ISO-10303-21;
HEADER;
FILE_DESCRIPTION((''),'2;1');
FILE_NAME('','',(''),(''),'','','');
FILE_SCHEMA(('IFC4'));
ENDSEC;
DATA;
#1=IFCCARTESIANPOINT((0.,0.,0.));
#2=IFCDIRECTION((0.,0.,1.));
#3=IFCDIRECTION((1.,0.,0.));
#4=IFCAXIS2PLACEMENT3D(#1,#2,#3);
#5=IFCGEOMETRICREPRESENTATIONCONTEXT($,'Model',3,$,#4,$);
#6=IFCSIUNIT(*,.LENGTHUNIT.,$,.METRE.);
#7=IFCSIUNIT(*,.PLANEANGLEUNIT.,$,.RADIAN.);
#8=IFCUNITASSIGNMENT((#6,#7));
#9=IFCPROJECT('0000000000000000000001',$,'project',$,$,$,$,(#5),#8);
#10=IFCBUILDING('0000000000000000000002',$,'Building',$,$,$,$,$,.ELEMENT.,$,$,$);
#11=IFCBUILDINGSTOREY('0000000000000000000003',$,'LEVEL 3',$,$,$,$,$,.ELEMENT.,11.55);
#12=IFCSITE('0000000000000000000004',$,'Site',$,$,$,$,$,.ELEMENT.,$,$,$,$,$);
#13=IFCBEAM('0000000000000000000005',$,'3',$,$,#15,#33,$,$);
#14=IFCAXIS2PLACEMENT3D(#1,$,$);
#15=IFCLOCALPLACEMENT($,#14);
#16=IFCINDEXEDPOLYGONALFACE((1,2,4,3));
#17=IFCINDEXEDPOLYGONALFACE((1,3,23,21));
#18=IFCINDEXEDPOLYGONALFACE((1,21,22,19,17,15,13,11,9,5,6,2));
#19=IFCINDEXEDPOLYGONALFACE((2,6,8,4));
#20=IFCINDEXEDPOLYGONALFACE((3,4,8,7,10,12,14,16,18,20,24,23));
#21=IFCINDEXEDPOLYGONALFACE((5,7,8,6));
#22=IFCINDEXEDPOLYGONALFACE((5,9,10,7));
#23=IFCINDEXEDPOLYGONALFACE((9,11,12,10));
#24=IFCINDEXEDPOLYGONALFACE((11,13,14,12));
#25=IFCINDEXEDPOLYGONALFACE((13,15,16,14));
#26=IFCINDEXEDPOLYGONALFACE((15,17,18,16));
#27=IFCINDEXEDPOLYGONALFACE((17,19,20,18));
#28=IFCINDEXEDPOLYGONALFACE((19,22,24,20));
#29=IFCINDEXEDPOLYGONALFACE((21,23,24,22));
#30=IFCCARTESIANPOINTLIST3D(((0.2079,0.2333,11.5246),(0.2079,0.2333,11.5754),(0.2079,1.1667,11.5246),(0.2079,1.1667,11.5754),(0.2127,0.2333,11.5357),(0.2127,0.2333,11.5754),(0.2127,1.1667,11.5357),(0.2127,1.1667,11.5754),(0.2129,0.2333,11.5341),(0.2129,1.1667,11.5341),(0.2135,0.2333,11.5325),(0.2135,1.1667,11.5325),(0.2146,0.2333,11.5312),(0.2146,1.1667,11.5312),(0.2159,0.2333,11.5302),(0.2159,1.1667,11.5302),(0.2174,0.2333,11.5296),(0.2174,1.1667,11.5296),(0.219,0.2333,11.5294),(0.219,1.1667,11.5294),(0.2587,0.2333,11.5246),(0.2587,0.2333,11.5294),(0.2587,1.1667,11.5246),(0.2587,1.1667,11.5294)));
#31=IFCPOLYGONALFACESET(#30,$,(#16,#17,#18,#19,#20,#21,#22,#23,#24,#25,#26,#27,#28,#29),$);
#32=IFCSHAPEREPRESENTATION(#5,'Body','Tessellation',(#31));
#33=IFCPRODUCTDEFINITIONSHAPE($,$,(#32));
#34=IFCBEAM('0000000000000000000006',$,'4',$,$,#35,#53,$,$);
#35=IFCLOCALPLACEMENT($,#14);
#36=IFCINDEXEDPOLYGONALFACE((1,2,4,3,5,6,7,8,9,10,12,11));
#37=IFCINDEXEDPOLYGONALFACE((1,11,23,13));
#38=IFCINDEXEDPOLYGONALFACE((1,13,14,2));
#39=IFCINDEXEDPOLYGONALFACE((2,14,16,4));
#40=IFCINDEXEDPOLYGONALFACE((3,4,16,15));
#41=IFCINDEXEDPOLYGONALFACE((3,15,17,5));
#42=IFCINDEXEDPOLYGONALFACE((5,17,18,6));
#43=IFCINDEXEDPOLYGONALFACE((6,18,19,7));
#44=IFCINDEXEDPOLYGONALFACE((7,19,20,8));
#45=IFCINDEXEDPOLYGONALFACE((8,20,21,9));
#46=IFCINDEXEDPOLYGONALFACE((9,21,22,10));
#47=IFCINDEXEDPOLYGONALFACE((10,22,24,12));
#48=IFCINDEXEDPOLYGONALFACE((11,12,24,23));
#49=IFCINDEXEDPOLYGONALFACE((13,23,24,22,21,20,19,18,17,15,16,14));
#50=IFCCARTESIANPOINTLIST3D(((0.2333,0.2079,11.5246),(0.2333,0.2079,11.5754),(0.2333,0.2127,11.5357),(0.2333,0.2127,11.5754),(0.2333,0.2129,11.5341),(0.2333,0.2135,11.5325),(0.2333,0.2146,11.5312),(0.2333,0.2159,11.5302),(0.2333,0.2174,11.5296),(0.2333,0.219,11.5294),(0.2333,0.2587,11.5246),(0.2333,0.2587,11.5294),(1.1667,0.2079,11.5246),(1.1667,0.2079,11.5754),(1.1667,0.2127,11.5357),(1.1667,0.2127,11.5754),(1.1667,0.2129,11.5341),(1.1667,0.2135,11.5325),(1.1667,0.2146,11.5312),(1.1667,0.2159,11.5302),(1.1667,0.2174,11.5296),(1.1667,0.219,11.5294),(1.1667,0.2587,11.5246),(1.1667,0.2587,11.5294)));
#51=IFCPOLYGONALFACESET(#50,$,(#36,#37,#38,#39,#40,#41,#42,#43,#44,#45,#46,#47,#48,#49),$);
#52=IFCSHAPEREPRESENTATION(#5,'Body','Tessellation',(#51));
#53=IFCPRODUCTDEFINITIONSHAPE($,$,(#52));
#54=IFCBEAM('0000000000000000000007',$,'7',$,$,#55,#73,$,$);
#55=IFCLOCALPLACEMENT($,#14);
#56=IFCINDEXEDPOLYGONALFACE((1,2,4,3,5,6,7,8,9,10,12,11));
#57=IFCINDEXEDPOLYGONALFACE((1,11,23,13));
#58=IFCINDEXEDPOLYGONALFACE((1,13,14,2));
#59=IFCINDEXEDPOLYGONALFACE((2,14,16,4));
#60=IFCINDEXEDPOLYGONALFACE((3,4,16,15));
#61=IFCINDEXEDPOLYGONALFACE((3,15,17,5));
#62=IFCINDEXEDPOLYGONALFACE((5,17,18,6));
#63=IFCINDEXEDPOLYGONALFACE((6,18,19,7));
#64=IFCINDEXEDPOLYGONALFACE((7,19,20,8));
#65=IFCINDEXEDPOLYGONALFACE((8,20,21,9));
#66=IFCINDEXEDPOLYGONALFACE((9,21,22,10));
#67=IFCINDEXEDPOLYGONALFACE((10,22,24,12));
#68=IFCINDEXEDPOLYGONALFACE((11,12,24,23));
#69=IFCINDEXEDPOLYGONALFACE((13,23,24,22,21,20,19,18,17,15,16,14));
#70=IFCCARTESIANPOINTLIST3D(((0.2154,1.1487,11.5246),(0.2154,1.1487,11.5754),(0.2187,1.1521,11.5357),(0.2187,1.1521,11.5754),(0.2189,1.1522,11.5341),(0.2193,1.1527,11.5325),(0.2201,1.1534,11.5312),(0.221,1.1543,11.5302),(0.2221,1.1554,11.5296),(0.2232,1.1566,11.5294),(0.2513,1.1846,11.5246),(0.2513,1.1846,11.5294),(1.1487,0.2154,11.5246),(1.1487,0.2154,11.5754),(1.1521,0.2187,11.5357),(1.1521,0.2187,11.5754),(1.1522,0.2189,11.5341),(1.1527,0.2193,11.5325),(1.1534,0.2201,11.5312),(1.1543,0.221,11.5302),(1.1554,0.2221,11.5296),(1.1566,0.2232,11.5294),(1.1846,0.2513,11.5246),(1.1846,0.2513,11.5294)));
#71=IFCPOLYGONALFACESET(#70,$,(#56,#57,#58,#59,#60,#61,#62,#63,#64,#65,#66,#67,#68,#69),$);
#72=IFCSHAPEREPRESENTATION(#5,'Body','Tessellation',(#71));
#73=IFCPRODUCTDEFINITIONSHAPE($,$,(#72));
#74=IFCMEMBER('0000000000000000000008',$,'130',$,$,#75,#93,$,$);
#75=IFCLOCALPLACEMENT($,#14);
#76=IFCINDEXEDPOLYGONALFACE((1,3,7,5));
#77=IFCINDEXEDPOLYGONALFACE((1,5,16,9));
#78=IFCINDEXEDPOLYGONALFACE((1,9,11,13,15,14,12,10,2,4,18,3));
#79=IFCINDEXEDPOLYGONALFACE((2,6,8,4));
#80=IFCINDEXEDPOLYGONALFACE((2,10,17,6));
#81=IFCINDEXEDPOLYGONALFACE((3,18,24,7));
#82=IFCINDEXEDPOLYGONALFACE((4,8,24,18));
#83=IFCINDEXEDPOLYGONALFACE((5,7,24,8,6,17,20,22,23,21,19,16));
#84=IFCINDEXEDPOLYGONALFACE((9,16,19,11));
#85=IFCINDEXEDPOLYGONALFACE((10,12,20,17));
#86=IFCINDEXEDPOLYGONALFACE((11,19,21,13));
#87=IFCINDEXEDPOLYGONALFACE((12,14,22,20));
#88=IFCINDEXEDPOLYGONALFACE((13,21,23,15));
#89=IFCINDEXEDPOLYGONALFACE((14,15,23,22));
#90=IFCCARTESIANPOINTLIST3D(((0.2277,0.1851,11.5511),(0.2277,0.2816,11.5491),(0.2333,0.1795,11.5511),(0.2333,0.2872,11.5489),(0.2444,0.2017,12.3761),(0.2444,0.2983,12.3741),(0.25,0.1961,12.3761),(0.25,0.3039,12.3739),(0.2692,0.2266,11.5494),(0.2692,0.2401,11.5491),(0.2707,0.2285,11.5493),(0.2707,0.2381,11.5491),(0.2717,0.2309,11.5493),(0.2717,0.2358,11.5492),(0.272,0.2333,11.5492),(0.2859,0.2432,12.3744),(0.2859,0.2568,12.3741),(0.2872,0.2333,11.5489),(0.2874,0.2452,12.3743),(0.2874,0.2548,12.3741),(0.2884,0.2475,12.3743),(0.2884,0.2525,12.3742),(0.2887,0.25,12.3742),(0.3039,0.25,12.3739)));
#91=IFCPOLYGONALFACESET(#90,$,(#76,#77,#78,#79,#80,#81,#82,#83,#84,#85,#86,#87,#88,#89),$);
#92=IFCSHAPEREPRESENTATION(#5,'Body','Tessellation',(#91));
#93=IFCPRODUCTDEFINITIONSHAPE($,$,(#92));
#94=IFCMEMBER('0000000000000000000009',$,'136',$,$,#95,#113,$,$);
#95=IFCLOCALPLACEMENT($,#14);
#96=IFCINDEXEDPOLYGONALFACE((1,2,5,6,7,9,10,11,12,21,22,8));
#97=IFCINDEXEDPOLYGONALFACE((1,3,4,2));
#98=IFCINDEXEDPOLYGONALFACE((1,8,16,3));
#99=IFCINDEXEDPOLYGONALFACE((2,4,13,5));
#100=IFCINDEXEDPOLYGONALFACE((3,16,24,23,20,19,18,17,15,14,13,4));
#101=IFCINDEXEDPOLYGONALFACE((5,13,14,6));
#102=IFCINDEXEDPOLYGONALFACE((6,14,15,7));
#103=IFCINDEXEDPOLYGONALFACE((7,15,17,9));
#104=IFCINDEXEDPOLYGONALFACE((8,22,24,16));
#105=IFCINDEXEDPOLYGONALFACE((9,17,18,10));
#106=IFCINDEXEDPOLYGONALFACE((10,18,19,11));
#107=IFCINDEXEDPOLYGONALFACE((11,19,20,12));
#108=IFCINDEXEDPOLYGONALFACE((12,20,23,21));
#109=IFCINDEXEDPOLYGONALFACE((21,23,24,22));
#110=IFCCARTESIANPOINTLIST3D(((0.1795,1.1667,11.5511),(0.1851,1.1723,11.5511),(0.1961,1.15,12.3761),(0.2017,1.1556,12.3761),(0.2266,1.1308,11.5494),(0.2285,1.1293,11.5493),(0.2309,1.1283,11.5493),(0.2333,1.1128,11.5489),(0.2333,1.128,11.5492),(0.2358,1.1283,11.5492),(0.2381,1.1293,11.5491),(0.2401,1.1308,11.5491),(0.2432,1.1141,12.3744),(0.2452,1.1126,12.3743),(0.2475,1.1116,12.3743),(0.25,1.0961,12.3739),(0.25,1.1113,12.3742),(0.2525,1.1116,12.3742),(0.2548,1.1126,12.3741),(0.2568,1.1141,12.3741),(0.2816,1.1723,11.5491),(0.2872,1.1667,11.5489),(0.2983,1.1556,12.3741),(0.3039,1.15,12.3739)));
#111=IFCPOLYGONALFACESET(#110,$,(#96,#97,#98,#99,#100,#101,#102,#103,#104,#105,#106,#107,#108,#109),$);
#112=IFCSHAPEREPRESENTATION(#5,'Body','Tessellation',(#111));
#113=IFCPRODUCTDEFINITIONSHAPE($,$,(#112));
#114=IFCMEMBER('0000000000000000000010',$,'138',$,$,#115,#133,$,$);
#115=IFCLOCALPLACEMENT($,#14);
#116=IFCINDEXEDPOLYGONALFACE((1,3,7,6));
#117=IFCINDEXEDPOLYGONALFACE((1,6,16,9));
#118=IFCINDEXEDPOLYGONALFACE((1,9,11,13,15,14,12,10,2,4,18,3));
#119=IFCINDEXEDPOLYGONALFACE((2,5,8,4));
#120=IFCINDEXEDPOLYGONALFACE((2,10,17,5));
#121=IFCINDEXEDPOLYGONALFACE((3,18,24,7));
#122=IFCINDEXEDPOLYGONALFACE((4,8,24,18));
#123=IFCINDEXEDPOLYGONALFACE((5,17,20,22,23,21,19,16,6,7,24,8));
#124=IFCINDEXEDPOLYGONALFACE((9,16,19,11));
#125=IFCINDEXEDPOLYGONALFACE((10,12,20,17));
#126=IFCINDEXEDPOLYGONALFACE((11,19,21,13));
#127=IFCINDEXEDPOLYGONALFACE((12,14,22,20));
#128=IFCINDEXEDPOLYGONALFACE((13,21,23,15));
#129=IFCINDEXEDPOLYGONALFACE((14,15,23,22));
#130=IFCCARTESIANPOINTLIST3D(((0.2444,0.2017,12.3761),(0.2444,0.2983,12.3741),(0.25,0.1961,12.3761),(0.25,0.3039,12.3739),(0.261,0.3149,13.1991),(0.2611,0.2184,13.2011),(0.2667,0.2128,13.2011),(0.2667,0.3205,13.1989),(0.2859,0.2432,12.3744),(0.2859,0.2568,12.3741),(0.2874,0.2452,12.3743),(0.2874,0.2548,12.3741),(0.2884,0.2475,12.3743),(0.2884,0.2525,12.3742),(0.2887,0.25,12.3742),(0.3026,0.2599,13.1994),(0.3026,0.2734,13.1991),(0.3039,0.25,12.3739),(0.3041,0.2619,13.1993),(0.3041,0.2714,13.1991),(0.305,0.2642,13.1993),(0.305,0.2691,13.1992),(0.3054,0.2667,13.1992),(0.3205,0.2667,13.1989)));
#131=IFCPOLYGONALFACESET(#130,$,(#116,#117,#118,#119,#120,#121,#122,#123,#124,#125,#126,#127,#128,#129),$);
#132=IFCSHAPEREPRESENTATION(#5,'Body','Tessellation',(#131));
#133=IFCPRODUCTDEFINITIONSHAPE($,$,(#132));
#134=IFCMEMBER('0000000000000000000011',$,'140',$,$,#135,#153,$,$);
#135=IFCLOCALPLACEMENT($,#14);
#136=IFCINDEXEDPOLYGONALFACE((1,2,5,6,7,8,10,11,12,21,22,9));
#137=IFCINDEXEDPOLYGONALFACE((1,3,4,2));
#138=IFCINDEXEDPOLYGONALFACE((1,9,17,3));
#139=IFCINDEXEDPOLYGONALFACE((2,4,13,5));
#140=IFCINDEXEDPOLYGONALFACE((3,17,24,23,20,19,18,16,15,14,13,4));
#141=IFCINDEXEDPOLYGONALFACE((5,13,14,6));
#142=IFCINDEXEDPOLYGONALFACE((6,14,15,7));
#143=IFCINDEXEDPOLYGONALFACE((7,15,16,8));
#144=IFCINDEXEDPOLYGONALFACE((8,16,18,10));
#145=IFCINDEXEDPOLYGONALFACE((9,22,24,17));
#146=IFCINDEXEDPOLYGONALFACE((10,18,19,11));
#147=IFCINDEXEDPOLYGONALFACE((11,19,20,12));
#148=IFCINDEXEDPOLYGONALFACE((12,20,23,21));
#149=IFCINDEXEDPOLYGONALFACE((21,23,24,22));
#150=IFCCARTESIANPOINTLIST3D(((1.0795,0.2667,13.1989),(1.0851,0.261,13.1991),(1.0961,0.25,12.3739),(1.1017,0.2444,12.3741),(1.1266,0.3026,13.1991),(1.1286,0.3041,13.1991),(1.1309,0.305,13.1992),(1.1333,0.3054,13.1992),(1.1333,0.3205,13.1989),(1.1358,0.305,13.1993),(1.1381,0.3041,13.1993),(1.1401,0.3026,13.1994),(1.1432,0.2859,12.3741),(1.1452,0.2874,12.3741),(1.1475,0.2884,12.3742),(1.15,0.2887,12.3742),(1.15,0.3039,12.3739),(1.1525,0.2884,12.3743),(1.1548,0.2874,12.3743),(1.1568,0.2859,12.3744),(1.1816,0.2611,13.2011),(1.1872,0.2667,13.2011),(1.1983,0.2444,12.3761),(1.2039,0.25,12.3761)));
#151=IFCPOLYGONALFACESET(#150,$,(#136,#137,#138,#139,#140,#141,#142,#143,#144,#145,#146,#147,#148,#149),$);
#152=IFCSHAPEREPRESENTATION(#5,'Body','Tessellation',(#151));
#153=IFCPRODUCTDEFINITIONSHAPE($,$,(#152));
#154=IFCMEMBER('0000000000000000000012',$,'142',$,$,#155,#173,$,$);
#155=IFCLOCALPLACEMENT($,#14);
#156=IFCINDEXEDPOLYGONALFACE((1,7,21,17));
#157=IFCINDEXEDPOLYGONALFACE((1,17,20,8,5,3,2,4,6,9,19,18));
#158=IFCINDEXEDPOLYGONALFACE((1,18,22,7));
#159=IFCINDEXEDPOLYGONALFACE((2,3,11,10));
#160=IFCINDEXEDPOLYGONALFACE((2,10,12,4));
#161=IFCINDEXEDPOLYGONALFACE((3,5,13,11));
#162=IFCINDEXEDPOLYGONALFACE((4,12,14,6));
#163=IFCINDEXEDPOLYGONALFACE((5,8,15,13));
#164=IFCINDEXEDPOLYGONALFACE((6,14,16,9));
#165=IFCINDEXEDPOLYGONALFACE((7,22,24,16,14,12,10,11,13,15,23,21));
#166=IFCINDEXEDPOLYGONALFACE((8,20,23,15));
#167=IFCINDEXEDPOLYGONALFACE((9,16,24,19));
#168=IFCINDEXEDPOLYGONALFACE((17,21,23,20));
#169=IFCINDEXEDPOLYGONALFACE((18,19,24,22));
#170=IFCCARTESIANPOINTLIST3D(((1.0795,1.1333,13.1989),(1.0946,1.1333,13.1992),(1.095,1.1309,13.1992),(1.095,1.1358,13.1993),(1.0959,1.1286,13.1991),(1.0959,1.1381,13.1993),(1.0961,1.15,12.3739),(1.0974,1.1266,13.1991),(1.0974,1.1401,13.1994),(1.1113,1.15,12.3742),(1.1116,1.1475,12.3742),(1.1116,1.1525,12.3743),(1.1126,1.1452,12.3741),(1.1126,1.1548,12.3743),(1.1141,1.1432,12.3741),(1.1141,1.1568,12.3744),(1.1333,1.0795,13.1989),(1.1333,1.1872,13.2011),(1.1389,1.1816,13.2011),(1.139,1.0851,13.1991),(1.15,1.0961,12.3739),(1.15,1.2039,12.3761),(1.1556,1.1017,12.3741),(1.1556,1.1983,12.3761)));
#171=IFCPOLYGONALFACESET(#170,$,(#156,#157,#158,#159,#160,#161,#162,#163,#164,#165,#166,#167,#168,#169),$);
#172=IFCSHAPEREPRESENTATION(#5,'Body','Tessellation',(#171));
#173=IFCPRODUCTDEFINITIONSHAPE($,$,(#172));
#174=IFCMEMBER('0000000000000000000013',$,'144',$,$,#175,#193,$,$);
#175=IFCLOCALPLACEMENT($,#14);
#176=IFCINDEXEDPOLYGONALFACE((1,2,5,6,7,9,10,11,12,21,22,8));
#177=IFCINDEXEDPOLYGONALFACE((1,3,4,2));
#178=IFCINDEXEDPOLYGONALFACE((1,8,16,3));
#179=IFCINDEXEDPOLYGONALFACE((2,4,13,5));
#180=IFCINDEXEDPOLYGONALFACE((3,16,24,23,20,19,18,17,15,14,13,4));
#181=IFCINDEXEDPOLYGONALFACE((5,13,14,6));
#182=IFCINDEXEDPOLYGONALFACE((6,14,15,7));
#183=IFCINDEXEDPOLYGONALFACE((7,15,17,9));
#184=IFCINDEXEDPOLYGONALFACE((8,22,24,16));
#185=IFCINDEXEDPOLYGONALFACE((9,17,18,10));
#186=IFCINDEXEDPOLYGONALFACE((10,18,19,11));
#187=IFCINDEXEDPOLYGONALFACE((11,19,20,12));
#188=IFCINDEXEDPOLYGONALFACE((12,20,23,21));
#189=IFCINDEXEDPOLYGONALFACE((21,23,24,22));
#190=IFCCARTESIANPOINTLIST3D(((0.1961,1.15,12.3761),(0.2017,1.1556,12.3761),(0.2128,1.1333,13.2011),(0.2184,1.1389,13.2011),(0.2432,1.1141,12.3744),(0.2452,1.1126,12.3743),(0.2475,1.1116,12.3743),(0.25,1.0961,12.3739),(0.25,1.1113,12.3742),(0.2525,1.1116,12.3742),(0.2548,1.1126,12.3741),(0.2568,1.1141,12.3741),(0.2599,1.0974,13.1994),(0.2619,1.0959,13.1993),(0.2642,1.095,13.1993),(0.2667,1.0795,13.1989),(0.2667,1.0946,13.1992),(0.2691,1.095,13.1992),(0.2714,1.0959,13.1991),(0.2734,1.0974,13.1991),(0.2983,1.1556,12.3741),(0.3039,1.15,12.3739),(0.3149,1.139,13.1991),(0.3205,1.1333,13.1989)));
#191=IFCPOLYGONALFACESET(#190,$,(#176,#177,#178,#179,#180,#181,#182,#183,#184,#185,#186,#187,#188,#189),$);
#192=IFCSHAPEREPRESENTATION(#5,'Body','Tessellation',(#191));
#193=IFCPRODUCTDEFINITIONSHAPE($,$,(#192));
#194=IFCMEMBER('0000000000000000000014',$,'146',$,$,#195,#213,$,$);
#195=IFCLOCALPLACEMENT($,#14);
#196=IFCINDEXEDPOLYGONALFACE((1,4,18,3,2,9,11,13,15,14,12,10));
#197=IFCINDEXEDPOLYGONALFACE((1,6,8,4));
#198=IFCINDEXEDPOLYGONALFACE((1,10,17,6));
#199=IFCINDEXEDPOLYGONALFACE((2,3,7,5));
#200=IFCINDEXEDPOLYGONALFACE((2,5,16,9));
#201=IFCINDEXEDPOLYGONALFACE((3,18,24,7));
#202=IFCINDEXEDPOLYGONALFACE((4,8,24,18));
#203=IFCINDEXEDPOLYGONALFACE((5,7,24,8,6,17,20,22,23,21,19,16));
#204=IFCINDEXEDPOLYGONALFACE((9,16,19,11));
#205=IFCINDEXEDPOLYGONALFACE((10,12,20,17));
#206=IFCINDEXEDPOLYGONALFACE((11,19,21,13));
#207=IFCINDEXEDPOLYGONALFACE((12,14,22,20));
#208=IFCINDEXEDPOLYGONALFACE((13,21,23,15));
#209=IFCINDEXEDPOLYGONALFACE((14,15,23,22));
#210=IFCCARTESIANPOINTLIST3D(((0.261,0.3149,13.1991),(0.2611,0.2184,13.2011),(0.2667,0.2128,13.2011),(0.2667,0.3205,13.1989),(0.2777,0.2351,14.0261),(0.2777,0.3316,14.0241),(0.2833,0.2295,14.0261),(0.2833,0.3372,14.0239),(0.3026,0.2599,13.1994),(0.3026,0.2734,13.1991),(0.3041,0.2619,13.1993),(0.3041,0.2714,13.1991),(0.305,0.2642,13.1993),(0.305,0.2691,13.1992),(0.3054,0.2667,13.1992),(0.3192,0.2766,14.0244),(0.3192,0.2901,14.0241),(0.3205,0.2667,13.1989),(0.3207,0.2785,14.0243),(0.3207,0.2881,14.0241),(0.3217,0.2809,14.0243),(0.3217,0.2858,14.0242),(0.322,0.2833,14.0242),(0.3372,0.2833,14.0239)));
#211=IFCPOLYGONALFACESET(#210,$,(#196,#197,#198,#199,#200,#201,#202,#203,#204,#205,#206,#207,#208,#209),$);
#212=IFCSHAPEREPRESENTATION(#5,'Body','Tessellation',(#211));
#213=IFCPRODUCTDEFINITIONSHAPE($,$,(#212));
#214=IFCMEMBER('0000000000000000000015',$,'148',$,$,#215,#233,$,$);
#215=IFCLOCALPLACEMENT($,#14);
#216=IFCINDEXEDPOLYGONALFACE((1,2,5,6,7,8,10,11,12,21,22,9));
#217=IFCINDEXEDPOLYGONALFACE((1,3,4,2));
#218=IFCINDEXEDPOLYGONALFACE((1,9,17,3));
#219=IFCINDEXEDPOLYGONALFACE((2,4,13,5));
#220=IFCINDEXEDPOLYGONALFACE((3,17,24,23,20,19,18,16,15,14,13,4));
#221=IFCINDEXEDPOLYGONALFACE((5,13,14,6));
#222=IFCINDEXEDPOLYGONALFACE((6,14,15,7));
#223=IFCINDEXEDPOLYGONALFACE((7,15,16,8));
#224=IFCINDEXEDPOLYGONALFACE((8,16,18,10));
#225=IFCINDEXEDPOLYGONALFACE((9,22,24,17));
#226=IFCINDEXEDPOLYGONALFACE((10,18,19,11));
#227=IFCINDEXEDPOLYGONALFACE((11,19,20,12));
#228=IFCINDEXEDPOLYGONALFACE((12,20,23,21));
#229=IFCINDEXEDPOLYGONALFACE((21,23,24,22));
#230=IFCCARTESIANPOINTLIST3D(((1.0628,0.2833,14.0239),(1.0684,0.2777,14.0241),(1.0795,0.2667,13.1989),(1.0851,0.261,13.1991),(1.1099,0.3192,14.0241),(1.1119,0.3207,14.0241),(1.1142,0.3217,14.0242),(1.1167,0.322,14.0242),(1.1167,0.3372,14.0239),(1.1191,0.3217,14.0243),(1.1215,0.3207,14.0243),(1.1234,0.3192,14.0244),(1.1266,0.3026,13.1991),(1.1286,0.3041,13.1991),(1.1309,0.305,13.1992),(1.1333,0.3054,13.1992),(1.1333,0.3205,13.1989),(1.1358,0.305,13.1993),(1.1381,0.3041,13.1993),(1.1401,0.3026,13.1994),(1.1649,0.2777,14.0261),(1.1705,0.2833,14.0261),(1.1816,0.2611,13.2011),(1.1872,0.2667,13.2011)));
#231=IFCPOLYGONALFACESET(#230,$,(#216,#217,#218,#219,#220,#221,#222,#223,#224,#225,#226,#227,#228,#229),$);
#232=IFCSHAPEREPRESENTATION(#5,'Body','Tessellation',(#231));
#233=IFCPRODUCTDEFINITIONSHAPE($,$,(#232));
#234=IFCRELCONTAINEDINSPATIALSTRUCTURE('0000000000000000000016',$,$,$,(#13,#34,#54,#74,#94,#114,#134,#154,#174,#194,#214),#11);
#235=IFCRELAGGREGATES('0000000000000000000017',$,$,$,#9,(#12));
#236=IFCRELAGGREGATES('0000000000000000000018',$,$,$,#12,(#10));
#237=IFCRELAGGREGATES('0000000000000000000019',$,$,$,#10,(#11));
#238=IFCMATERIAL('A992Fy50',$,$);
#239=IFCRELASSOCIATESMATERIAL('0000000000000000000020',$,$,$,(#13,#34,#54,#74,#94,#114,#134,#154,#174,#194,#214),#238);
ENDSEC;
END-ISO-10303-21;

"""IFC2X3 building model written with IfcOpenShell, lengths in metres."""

from ifc_helpers import new_model, si_unit, frame, origin_with_axes, origin_2d_with_axis, place, context, project, spatial, l_section, extrude, material, element, save


model = new_model("IFC2X3")

# Units and contexts
model_context = context("Model", 3, world=origin_with_axes())
ifc_project = project(units=[si_unit("LENGTHUNIT", "METRE"), si_unit("PLANEANGLEUNIT", "RADIAN")], contexts=[model_context])

# Site, building, storey
site = spatial("IfcSite", under=ifc_project, Name="Site", CompositionType="ELEMENT")
building = spatial("IfcBuilding", under=site, Name="Building", CompositionType="ELEMENT")
storey = spatial("IfcBuildingStorey", under=building, Name="LEVEL 3", CompositionType="ELEMENT", Elevation=11.55)

# Beams
ifc_material = material(Name="A992Fy50")
for number, where, z_axis, x_axis, name in (
    (1, (0.2333, 1.1667, 11.55), (0.0, -1.0, 0.0), (1.0, 0.0, 0.0), "3"),
    (2, (0.2333, 0.2333, 11.55), (1.0, 0.0, 0.0), (0.0, 1.0, 0.0), "4"),
):
    element("IfcBeam", number, at=place(None, frame(where, z_axis=z_axis, x_axis=x_axis)), inside=storey, material=ifc_material, Name=name, context=model_context, shape_type="SweptSolid", body=[
        extrude(l_section(Depth=0.0508, Width=0.0508, Thickness=0.0048, FilletRadius=0.0063, at=origin_2d_with_axis()), origin_with_axes(), (0.0, 0.0, 1.0), 0.9333),
    ])
beam_placement = place(None, frame((0.2333, 1.1667, 11.55), z_axis=(0.707107, -0.707107, 0.0), x_axis=(0.707107, 0.707107, 0.0)))
element("IfcBeam", 3, at=beam_placement, inside=storey, material=ifc_material, Name="7", context=model_context, shape_type="SweptSolid", body=[
    extrude(l_section(Depth=0.0508, Width=0.0508, Thickness=0.0048, FilletRadius=0.0063, at=origin_2d_with_axis()), origin_with_axes(), (0.0, 0.0, 1.0), 1.3199),
])

# Members
for number, where, z_axis, x_axis, name in (
    (4, (0.2333, 0.2333, 11.55), (0.020194, 0.020194, 0.999592), (-0.707107, 0.707107, 0.0), "130"),
    (5, (0.2333, 1.1667, 11.55), (0.020194, -0.020194, 0.999592), (0.707107, 0.707107, 0.0), "136"),
    (6, (0.25, 0.25, 12.375), (0.020194, 0.020194, 0.999592), (-0.707107, 0.707107, 0.0), "138"),
    (7, (1.15, 0.25, 12.375), (-0.020194, 0.020194, 0.999592), (-0.707107, -0.707107, 0.0), "140"),
    (8, (1.15, 1.15, 12.375), (-0.020194, -0.020194, 0.999592), (0.707107, -0.707107, 0.0), "142"),
    (9, (0.25, 1.15, 12.375), (0.020194, -0.020194, 0.999592), (0.707107, 0.707107, 0.0), "144"),
    (10, (0.2667, 0.2667, 13.2), (0.020194, 0.020194, 0.999592), (-0.707107, 0.707107, 0.0), "146"),
    (11, (1.1333, 0.2667, 13.2), (-0.020194, 0.020194, 0.999592), (-0.707107, -0.707107, 0.0), "148"),
):
    element("IfcMember", number, at=place(None, frame(where, z_axis=z_axis, x_axis=x_axis)), inside=storey, material=ifc_material, Name=name, context=model_context, shape_type="SweptSolid", body=[
        extrude(l_section(Depth=0.0762, Width=0.0762, Thickness=0.0079, FilletRadius=0.0096, at=origin_2d_with_axis()), origin_with_axes(), (0.0, 0.0, 1.0), 0.8253),
    ])

save(model, "model.ifc")
